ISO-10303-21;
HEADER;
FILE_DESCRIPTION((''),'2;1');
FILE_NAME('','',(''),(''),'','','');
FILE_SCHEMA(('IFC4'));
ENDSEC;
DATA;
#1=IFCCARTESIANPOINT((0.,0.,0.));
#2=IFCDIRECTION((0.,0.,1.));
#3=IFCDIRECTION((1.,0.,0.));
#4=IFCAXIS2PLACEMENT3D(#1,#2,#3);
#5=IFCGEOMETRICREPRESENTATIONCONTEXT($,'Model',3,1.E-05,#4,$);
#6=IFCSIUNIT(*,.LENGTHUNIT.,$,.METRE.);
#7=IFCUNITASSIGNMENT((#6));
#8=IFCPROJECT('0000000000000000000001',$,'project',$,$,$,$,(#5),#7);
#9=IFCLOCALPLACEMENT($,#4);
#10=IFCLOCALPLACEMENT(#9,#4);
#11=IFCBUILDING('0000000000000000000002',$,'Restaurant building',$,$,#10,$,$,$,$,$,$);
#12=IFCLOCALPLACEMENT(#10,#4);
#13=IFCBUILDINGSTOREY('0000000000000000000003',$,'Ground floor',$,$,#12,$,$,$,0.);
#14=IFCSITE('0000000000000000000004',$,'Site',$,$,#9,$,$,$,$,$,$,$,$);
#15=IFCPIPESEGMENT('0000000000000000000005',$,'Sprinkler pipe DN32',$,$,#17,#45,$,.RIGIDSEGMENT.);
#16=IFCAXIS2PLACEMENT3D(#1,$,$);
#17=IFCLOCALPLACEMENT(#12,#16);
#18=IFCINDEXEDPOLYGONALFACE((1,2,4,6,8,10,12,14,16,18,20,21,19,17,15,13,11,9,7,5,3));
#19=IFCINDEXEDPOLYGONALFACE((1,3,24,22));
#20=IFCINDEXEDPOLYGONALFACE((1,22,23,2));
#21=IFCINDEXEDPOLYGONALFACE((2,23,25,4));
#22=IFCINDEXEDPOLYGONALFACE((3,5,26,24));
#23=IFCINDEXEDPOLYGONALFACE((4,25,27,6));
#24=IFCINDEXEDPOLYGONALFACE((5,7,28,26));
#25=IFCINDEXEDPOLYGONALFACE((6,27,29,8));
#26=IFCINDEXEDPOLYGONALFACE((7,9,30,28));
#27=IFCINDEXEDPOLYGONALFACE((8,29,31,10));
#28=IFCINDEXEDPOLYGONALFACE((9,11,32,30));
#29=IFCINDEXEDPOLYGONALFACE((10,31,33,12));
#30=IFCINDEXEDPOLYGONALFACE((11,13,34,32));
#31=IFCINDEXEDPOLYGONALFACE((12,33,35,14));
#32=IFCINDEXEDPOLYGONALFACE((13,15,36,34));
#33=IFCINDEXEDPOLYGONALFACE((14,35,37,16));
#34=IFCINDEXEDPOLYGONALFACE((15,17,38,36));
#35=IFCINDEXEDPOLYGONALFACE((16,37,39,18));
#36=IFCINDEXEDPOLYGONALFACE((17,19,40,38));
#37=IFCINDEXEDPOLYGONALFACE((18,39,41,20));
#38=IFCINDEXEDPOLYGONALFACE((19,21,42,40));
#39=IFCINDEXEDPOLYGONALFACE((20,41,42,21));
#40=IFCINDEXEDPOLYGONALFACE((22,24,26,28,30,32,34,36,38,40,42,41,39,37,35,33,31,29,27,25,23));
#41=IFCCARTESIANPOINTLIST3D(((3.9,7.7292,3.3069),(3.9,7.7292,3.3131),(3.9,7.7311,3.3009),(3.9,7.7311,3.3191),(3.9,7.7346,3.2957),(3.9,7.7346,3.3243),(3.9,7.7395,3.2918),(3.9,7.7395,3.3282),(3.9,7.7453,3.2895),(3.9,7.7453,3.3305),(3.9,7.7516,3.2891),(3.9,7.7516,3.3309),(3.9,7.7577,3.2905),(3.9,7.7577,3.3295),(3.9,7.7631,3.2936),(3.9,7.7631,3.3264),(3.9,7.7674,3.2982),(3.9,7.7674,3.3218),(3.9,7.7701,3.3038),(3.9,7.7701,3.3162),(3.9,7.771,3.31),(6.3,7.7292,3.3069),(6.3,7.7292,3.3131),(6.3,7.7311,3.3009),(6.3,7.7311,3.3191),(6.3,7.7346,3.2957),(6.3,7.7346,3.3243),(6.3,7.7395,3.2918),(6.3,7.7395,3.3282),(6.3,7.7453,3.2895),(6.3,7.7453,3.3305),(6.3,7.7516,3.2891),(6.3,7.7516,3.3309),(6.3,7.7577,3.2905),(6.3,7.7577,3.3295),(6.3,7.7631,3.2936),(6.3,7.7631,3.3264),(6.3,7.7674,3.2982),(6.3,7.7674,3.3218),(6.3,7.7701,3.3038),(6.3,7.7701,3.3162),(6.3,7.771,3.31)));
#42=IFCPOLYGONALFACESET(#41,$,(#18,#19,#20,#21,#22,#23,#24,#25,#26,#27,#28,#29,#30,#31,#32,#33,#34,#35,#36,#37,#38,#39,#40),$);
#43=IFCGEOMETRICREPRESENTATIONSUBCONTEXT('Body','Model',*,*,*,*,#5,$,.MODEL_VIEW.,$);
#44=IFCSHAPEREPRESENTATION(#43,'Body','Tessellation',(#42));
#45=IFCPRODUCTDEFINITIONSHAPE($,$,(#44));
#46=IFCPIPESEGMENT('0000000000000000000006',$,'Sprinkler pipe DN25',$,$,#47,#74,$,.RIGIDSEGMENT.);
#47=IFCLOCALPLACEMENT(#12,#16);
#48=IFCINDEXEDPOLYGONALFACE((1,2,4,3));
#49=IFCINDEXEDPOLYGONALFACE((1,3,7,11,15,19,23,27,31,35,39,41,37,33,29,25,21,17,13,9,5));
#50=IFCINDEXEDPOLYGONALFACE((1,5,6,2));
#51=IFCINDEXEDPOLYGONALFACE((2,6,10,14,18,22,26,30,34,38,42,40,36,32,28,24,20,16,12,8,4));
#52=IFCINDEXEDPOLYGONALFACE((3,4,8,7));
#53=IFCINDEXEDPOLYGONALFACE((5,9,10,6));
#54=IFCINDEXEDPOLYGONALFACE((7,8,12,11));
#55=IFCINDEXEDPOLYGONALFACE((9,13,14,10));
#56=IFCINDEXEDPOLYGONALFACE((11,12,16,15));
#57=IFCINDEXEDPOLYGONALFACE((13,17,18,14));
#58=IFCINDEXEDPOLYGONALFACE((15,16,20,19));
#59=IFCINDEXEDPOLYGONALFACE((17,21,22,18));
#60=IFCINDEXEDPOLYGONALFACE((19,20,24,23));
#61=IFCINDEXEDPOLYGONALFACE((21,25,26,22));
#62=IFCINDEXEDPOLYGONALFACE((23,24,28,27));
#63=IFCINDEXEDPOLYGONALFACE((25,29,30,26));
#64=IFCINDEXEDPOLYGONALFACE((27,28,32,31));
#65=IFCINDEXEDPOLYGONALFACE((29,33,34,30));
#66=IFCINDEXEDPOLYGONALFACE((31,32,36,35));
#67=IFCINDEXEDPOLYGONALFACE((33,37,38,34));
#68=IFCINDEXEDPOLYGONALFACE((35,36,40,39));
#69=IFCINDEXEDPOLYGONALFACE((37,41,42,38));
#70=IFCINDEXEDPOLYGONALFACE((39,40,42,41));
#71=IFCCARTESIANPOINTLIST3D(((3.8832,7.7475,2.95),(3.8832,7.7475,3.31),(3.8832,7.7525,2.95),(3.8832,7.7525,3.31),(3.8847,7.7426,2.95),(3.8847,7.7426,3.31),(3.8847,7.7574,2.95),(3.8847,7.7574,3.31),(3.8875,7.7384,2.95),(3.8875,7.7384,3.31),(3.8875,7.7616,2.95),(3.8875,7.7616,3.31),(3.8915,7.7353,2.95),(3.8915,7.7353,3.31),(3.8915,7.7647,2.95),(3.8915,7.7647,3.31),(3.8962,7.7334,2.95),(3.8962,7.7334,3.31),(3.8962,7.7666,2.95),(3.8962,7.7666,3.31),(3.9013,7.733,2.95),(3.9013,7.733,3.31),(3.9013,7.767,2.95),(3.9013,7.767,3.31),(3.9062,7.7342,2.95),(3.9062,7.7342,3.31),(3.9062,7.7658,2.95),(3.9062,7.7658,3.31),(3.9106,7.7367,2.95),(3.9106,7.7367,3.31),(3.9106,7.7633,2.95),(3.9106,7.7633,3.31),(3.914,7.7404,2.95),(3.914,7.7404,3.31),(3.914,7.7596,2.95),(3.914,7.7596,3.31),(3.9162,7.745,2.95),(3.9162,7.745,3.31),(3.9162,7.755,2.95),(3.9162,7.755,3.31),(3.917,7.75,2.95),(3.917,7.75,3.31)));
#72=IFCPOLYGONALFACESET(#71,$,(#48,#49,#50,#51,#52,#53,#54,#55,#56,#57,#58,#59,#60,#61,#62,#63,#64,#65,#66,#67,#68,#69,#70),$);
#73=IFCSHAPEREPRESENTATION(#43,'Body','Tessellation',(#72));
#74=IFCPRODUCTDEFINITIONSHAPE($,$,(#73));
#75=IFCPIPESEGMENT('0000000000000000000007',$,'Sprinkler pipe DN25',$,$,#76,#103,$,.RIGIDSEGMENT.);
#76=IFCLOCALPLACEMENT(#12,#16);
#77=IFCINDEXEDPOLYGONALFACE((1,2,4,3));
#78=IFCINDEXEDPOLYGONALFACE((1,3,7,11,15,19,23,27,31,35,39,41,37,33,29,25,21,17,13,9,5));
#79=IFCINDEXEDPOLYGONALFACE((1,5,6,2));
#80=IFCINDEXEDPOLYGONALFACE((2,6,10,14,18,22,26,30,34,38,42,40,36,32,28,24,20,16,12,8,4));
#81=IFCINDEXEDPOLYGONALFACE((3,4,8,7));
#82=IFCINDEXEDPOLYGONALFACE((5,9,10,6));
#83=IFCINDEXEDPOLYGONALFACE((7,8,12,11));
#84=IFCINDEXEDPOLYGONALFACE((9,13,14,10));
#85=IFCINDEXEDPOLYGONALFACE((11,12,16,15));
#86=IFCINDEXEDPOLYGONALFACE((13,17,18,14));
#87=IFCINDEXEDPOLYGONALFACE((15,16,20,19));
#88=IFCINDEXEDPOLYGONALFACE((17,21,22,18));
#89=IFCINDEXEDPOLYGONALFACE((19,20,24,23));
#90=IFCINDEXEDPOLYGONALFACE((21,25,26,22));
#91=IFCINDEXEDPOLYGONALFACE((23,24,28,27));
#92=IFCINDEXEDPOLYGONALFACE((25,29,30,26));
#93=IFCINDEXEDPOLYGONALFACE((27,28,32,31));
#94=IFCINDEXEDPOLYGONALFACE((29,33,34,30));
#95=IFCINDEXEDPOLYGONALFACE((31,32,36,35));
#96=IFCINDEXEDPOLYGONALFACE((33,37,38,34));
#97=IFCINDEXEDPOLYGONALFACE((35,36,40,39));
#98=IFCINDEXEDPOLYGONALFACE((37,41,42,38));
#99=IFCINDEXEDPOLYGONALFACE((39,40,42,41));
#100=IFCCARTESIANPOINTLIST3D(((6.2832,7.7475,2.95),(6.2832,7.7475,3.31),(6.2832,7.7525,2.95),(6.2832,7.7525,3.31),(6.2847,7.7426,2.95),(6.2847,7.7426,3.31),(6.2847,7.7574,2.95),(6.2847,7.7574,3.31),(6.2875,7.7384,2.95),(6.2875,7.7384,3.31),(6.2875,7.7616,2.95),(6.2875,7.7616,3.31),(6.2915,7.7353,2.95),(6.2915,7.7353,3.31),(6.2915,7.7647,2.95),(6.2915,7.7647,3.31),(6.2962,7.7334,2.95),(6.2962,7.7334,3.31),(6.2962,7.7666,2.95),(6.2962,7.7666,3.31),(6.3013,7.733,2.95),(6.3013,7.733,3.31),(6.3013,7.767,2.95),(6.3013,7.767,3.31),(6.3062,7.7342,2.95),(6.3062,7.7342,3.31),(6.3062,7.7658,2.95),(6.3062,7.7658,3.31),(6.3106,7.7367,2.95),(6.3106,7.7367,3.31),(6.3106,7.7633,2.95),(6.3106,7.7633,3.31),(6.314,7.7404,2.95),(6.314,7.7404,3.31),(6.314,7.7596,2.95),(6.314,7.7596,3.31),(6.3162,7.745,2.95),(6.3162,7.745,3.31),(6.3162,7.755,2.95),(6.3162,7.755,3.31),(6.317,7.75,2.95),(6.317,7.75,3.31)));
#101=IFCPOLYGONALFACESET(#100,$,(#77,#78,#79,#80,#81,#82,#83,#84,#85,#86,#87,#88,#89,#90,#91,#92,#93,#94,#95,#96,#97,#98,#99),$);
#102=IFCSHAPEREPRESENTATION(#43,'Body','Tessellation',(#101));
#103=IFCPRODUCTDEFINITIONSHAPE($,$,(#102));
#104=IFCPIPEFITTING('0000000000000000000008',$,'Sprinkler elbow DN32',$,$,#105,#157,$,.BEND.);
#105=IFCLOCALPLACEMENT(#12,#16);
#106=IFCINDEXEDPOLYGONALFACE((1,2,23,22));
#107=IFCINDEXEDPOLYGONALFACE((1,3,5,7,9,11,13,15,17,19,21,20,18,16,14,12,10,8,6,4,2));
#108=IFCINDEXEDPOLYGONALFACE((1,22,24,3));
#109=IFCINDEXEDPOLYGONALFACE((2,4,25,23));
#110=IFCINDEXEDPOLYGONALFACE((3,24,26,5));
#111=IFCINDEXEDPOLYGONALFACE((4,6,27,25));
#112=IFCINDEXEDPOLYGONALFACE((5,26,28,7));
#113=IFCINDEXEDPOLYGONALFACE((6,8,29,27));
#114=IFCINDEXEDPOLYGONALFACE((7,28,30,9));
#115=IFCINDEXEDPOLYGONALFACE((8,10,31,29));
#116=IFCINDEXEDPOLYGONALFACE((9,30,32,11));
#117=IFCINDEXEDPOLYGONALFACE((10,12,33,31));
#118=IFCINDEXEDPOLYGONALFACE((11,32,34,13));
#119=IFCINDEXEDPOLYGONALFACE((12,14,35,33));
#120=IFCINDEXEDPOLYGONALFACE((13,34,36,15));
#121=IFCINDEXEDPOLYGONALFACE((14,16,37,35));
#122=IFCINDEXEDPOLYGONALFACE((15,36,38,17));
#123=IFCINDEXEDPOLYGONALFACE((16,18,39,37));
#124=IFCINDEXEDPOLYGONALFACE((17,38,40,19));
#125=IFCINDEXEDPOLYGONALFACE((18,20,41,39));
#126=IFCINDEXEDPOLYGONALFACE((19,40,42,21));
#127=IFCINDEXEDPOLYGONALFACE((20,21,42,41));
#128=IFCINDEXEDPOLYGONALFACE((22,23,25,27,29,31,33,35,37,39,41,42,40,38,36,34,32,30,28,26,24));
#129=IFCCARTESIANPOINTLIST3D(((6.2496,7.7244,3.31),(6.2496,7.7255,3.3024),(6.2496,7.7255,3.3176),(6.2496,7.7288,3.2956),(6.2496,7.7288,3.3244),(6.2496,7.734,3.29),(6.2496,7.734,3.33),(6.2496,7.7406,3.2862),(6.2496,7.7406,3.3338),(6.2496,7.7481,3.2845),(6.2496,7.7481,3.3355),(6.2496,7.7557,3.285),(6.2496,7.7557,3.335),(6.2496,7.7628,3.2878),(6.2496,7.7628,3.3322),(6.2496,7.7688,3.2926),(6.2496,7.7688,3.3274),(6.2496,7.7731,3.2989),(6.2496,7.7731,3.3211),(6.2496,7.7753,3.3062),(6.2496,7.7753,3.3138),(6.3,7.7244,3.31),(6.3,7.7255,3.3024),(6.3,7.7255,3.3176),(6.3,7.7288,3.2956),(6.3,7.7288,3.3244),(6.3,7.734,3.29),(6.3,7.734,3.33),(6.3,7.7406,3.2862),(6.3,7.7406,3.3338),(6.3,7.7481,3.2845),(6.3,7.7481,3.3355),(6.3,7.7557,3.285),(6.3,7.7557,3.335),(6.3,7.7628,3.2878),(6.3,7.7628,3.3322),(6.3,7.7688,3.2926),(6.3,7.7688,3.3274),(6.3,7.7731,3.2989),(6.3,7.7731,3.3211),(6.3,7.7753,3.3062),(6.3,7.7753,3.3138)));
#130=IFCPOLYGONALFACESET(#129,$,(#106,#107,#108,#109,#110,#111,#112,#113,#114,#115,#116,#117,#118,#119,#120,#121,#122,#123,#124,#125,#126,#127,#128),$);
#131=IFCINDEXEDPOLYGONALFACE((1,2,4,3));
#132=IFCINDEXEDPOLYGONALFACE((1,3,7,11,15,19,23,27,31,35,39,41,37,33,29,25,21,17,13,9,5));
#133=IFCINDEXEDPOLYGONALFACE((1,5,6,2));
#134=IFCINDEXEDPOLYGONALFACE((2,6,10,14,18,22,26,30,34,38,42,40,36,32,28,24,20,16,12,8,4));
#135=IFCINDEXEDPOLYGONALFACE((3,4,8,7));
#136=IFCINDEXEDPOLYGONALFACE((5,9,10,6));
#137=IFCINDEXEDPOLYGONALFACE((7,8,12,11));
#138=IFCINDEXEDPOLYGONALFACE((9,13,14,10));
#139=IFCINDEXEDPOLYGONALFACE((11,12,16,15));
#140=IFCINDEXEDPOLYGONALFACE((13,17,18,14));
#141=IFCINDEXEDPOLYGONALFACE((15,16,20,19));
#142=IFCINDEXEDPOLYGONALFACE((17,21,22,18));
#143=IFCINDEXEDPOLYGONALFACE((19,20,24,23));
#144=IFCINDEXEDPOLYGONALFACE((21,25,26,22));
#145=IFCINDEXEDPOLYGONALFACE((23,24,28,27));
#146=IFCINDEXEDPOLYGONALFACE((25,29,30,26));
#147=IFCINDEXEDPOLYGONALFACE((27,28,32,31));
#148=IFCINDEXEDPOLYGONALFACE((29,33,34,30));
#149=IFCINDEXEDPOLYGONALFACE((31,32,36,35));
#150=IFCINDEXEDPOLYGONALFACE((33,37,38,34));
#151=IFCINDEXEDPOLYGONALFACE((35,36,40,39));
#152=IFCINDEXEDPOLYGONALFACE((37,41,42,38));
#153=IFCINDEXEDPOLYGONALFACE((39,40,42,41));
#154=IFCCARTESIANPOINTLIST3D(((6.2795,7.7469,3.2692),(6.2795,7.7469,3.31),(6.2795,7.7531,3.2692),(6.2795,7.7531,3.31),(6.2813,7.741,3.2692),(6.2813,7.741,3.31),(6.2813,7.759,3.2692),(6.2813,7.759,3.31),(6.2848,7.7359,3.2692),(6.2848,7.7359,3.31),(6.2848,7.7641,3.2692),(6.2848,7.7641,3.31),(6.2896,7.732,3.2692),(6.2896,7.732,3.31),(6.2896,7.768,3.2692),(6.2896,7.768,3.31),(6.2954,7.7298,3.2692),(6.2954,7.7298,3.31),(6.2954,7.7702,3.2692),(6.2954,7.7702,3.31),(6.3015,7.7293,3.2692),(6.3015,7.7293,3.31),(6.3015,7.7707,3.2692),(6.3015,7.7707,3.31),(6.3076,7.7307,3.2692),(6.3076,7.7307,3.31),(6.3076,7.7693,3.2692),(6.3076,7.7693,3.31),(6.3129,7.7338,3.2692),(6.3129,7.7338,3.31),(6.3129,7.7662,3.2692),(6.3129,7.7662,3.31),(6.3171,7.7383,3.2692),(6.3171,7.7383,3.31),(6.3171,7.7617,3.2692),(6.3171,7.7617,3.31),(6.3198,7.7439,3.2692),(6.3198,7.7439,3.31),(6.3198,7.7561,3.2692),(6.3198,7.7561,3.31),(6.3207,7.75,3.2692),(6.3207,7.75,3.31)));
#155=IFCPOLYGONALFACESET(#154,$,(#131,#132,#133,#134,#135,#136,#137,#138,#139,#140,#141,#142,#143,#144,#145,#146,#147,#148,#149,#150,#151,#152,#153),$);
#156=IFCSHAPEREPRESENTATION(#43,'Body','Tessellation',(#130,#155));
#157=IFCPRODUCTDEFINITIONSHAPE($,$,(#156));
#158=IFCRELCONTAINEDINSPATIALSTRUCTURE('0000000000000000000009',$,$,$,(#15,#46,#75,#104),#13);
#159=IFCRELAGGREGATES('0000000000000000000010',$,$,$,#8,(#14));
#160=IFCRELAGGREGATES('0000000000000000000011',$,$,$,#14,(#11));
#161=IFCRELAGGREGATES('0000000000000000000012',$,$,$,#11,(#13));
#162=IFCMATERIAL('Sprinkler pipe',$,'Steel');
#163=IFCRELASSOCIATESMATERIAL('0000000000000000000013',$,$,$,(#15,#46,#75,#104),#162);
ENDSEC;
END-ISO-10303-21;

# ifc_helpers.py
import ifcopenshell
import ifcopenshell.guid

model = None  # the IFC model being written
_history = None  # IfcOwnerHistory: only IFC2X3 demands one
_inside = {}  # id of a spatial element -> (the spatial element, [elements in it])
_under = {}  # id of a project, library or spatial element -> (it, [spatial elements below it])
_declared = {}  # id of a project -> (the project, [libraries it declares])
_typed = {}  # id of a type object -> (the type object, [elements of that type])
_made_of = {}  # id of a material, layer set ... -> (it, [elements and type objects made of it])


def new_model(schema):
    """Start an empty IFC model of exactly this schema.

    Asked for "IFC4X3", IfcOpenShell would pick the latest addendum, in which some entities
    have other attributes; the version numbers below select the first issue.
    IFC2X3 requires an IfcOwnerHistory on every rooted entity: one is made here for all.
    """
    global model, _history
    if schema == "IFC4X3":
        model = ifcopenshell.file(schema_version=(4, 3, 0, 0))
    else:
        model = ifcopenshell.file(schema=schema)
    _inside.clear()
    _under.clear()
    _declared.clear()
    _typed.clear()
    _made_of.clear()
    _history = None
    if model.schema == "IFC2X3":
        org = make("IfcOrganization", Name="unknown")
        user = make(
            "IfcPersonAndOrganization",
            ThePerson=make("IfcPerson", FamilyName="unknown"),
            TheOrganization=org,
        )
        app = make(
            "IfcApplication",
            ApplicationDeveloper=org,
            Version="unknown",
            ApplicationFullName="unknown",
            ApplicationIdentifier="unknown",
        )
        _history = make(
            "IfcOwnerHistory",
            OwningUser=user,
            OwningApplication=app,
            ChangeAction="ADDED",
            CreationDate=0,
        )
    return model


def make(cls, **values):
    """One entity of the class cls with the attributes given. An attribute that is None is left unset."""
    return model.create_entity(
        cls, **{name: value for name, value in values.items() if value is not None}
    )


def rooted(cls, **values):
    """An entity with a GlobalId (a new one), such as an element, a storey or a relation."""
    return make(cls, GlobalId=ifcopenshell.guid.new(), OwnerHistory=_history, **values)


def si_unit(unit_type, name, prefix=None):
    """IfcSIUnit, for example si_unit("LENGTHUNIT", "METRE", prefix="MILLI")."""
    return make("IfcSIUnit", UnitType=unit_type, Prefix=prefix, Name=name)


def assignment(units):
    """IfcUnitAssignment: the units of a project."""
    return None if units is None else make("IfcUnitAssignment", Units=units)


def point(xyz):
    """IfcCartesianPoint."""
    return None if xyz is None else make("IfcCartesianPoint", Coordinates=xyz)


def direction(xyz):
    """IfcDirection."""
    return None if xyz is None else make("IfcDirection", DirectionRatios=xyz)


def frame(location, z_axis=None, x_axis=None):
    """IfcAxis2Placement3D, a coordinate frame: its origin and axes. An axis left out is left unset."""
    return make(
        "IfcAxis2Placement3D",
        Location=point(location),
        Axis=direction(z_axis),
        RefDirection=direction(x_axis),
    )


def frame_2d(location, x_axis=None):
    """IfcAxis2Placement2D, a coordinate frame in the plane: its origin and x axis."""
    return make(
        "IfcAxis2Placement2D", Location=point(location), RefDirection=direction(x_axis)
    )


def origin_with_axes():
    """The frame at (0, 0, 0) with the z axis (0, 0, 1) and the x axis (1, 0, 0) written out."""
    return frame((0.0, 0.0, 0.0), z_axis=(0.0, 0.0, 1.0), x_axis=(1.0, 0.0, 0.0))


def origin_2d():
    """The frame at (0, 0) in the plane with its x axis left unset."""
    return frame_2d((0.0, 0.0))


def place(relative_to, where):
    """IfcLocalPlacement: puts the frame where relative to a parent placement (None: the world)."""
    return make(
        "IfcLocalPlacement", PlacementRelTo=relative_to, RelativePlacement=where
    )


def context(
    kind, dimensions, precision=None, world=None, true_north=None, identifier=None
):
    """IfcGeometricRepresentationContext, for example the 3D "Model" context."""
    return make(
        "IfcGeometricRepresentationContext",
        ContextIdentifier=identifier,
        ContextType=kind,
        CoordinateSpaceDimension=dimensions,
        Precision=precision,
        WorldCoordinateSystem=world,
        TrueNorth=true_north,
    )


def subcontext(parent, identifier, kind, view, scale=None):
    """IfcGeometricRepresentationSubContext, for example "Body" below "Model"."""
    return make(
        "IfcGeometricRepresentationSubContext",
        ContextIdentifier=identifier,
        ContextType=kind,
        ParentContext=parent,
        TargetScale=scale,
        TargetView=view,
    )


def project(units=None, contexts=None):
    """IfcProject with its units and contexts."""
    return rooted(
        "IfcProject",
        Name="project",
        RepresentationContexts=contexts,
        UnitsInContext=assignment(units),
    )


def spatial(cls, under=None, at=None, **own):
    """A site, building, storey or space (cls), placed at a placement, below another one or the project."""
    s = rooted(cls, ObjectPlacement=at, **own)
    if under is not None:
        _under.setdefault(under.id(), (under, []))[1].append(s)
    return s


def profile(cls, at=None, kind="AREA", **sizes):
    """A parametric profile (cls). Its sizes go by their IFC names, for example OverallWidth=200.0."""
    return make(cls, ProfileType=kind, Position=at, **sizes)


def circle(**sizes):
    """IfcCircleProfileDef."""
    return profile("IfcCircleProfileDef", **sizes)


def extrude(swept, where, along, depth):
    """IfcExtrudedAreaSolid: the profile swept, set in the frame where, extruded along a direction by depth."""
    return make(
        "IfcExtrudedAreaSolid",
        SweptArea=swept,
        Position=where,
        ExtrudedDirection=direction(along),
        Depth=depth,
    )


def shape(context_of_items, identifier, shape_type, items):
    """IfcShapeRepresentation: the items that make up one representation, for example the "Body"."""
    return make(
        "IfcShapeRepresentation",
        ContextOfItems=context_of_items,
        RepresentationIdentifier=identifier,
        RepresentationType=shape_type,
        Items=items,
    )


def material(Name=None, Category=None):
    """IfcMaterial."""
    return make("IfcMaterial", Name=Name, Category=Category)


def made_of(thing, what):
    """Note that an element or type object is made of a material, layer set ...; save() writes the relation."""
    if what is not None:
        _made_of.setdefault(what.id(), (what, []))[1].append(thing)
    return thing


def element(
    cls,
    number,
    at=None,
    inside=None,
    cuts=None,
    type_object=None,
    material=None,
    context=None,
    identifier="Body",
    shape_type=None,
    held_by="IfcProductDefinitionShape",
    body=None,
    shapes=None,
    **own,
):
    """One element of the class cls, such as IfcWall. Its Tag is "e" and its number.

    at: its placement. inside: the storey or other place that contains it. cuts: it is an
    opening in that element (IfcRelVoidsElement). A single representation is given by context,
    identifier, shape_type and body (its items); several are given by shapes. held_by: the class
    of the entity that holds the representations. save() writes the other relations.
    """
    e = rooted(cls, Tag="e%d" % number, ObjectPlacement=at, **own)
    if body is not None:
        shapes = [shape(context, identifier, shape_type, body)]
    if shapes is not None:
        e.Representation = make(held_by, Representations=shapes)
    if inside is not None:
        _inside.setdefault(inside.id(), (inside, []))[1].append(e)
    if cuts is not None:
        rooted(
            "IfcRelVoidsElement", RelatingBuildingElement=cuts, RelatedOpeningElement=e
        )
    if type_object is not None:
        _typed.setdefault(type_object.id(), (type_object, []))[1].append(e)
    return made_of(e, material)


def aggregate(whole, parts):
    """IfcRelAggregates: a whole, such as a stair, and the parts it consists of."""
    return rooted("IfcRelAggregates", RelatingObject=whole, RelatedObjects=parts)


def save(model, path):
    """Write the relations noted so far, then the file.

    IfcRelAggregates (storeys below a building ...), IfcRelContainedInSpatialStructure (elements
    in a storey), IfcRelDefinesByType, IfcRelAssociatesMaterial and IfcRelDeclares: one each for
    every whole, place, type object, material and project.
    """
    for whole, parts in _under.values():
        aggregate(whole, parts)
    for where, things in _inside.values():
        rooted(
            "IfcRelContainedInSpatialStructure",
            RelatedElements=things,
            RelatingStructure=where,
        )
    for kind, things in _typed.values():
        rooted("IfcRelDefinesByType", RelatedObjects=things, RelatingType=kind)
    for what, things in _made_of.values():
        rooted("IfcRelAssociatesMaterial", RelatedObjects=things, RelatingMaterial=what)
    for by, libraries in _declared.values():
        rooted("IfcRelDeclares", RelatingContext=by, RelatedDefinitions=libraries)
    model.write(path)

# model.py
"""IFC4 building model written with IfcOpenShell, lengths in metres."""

from ifc_helpers import new_model, si_unit, frame, origin_with_axes, origin_2d, place, context, subcontext, project, spatial, circle, extrude, material, element, save


model = new_model("IFC4")

# Units and contexts
model_context = context("Model", 3, precision=1e-05, world=origin_with_axes())
body_context = subcontext(model_context, "Body", "Model", "MODEL_VIEW")
ifc_project = project(units=[si_unit("LENGTHUNIT", "METRE")], contexts=[model_context])

# Site, building, storey
site_placement = place(None, origin_with_axes())
site = spatial("IfcSite", under=ifc_project, at=site_placement, Name="Site")
building_placement = place(site_placement, origin_with_axes())
building = spatial("IfcBuilding", under=site, at=building_placement, Name="Restaurant building")
storey_placement = place(building_placement, origin_with_axes())
storey = spatial("IfcBuildingStorey", under=building, at=storey_placement, Name="Ground floor", Elevation=0.0)

# Pipe segments
ifc_material_1 = material(Name="Sprinkler pipe", Category="Steel")
pipe_segment_placement = place(storey_placement, frame((3.9, 7.75, 3.31)))
element("IfcPipeSegment", 1, at=pipe_segment_placement, inside=storey, material=ifc_material_1, Name="Sprinkler pipe DN32", PredefinedType="RIGIDSEGMENT", context=body_context, shape_type="SweptSolid", body=[
    extrude(circle(Radius=0.021, at=origin_2d()), frame((0.0, 0.0, 0.0), z_axis=(1.0, 0.0, 0.0), x_axis=(0.0, 1.0, 0.0)), (0.0, 0.0, 1.0), 2.4),
])
for number, where, name in (
    (2, (3.9, 7.75, 3.31), "Sprinkler pipe DN25"),
    (3, (6.3, 7.75, 3.31), "Sprinkler pipe DN25"),
):
    element("IfcPipeSegment", number, at=place(storey_placement, frame(where)), inside=storey, material=ifc_material_1, Name=name, PredefinedType="RIGIDSEGMENT", context=body_context, shape_type="SweptSolid", body=[
        extrude(circle(Radius=0.017, at=origin_2d()), frame((0.0, 0.0, 0.0), z_axis=(0.0, 0.0, -1.0), x_axis=(1.0, 0.0, 0.0)), (0.0, 0.0, 1.0), 0.36),
    ])

# Pipe fitting
pipe_fitting_1_placement = place(storey_placement, frame((6.3, 7.75, 3.31)))
element("IfcPipeFitting", 4, at=pipe_fitting_1_placement, inside=storey, material=ifc_material_1, Name="Sprinkler elbow DN32", PredefinedType="BEND", context=body_context, shape_type="SweptSolid", body=[
    extrude(circle(Radius=0.0256, at=origin_2d()), frame((0.0, 0.0, 0.0), z_axis=(-1.0, 0.0, 0.0), x_axis=(0.0, -1.0, 0.0)), (0.0, 0.0, 1.0), 0.0504),
    extrude(circle(Radius=0.0207, at=origin_2d()), frame((0.0, 0.0, 0.0), z_axis=(0.0, 0.0, -1.0), x_axis=(1.0, 0.0, 0.0)), (0.0, 0.0, 1.0), 0.0408),
])

save(model, "model.ifc")
